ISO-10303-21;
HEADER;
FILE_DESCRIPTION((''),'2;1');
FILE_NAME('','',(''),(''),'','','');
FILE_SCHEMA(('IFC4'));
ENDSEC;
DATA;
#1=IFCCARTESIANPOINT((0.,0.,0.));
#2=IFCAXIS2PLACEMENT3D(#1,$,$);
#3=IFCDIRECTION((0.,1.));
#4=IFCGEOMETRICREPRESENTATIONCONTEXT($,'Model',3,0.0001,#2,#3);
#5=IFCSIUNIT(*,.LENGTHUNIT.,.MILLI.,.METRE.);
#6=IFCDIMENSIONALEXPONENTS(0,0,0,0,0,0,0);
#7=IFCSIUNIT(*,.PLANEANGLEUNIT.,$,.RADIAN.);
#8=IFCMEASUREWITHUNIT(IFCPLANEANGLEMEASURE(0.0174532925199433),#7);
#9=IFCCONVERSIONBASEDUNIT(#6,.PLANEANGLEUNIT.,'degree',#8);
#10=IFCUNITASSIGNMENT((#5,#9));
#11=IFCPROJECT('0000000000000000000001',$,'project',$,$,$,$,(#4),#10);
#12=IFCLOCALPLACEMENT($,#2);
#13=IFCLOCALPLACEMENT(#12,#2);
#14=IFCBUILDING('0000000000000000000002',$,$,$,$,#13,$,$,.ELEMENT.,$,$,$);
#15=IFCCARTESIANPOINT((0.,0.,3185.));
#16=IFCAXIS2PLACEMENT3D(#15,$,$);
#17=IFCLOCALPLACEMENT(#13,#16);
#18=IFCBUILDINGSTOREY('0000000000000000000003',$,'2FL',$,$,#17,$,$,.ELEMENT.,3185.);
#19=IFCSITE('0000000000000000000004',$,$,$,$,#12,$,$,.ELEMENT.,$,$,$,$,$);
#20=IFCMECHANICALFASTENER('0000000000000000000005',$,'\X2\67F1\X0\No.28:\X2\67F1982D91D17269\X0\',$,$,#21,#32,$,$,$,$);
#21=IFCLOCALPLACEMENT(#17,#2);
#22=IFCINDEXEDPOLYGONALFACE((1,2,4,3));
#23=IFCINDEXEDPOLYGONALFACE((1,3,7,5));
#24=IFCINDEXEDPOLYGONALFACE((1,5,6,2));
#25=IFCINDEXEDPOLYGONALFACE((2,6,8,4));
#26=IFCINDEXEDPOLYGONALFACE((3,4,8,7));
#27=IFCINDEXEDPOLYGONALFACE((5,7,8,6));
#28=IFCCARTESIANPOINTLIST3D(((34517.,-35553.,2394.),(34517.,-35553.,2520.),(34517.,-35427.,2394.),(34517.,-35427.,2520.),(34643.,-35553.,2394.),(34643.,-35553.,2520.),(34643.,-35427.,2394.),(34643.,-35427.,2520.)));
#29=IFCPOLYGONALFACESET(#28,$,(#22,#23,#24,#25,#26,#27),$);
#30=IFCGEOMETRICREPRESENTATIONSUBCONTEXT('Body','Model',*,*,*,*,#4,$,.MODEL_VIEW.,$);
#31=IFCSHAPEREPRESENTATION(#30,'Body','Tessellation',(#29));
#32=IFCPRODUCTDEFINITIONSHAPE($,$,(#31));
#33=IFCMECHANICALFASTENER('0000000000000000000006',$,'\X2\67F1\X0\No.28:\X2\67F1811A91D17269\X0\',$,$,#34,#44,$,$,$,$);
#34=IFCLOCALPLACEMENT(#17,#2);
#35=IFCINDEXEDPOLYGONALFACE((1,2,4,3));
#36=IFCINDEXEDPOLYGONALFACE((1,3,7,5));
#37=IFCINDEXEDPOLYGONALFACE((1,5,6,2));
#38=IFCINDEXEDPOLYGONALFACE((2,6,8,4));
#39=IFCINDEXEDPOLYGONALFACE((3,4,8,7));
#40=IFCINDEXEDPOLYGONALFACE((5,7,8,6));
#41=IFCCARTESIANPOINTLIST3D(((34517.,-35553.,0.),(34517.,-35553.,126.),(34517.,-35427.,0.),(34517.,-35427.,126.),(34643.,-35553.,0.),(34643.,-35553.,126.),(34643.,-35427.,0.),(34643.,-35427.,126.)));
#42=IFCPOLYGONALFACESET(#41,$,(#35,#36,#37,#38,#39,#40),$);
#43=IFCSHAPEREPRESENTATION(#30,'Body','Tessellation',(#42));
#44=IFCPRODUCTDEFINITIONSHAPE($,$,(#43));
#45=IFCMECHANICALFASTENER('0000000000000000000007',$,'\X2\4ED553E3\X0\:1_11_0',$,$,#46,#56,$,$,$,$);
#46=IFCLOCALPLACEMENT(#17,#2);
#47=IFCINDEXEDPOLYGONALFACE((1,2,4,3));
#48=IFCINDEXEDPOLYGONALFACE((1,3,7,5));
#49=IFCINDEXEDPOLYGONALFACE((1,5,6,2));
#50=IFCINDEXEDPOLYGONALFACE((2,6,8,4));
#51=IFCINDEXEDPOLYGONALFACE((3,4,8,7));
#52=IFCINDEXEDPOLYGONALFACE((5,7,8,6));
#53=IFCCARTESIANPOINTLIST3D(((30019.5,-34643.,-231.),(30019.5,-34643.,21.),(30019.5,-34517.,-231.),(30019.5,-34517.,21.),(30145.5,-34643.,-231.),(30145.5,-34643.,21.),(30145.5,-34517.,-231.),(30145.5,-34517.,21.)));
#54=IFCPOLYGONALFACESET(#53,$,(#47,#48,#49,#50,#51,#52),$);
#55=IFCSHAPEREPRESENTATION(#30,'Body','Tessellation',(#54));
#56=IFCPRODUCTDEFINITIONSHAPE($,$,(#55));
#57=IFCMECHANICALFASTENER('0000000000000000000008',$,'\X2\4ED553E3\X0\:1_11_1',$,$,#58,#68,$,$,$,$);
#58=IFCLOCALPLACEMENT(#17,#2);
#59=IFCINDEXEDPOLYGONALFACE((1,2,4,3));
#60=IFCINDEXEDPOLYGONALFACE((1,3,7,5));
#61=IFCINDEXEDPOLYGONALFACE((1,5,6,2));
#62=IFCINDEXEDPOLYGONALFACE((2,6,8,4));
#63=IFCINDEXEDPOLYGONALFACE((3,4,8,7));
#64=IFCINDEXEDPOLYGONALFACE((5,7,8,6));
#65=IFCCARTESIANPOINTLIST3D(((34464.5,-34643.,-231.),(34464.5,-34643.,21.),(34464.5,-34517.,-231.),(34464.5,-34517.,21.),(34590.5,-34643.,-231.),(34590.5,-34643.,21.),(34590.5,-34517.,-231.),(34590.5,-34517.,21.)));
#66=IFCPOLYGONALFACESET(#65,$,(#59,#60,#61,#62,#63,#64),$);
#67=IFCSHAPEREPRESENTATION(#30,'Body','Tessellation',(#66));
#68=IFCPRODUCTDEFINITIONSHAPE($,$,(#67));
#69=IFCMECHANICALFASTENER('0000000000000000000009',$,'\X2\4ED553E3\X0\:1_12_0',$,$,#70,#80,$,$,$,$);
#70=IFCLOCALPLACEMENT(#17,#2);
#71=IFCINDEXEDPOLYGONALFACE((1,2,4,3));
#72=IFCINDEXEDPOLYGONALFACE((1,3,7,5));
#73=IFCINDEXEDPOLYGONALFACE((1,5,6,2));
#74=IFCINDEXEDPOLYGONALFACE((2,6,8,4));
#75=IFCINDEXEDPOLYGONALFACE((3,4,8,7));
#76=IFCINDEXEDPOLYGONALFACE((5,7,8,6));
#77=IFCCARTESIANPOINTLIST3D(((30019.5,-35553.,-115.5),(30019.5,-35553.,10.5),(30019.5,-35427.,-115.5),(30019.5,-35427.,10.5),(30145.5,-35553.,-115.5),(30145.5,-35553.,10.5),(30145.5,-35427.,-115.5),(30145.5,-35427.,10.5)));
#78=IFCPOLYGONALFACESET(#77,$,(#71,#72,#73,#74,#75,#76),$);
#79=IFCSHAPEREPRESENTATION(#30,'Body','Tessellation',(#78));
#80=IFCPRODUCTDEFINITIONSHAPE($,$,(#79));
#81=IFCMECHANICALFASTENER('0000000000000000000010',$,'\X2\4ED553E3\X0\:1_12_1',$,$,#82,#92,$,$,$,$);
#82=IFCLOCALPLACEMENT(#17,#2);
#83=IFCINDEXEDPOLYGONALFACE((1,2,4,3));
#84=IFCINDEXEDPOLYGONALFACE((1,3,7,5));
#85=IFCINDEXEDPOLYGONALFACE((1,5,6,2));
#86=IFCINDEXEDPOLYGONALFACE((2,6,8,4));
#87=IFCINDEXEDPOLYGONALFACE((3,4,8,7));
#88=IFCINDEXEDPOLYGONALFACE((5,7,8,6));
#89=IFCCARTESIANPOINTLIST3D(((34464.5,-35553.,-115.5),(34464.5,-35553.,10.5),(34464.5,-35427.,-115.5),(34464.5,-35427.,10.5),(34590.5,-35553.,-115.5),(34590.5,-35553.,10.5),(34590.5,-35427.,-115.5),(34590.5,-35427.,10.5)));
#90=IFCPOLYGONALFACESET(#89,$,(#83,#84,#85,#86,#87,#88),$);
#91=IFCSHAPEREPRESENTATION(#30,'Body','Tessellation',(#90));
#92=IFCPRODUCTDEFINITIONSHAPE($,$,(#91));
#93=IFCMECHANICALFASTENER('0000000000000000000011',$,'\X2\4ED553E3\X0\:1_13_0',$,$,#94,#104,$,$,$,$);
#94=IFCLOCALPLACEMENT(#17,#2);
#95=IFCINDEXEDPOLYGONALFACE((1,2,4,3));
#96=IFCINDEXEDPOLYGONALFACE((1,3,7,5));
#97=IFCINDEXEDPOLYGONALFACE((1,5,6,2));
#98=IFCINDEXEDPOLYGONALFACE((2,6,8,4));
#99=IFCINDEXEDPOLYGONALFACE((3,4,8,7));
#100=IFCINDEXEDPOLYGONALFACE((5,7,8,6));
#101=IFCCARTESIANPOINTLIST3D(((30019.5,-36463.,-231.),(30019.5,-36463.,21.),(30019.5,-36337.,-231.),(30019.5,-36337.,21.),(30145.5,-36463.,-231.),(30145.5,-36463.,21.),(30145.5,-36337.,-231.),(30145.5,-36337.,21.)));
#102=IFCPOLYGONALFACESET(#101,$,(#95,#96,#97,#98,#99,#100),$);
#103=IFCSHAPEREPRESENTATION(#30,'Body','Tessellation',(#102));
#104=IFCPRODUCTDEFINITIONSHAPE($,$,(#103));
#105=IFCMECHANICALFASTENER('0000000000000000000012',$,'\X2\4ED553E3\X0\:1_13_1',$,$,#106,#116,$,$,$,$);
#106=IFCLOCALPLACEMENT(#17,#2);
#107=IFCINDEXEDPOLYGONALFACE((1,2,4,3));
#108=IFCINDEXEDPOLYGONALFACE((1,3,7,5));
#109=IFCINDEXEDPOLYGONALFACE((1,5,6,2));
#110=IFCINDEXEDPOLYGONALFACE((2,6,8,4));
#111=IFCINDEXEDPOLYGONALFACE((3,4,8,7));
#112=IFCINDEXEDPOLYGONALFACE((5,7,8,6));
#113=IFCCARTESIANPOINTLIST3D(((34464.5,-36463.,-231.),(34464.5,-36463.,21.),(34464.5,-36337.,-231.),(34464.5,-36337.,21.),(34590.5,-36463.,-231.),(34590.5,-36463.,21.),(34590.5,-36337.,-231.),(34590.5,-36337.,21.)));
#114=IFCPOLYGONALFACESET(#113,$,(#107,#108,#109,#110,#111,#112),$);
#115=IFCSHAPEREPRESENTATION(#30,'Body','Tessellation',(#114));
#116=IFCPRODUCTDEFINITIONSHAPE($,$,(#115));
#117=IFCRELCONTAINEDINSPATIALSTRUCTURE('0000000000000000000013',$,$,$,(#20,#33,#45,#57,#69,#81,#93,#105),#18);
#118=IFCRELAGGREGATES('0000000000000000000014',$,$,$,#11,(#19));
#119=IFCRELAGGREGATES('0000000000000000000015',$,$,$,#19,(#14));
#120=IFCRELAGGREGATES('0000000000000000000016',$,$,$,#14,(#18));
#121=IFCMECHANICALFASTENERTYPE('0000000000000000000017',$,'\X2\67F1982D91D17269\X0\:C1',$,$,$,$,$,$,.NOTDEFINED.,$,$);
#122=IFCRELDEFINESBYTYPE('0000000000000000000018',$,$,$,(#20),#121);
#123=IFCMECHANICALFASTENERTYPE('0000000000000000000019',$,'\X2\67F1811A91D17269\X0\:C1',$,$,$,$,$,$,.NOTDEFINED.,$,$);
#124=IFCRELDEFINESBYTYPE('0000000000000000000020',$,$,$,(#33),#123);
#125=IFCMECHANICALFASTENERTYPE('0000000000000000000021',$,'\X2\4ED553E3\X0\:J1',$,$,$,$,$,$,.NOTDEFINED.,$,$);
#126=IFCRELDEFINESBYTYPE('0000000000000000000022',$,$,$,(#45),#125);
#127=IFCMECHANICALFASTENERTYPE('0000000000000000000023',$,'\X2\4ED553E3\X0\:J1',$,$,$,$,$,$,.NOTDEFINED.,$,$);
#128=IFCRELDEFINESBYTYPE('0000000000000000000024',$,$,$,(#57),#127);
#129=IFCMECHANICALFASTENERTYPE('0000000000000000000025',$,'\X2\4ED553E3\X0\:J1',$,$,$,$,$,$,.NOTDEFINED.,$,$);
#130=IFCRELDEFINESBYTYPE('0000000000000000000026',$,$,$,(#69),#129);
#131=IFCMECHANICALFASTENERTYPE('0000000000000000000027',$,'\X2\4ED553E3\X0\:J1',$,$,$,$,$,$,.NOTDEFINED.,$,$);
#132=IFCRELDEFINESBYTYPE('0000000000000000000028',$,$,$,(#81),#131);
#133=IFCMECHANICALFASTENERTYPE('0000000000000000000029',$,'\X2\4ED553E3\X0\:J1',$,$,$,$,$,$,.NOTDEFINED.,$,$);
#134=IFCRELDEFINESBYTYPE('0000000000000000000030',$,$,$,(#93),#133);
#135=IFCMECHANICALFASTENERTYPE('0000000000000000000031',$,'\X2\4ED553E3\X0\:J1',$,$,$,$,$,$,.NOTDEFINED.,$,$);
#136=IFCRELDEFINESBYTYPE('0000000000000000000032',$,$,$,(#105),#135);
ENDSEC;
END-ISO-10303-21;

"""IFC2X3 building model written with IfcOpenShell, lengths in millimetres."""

from ifc_helpers import new_model, entity, si_unit, converted_unit, direction, frame, origin, origin_with_axes, origin_2d, place, context, subcontext, project, spatial, rectangle, extrude, type_object, element, save


model = new_model("IFC2X3")

# Units and contexts
model_context = context("Model", 3, precision=0.0001, world=origin(), true_north=direction((0.0, 1.0)))
body_context = subcontext(model_context, "Body", "Model", "MODEL_VIEW")
ifc_project = project(units=[si_unit("LENGTHUNIT", "METRE", prefix="MILLI"), converted_unit("PLANEANGLEUNIT", "degree", entity("IfcPlaneAngleMeasure", 0.0174532925199433), si_unit("PLANEANGLEUNIT", "RADIAN"), dimensions=[0, 0, 0, 0, 0, 0, 0])], contexts=[model_context])

# Site, building, storey
site_placement = place(None, origin())
site = spatial("IfcSite", under=ifc_project, at=site_placement, CompositionType="ELEMENT")
building_placement = place(site_placement, origin())
building = spatial("IfcBuilding", under=site, at=building_placement, CompositionType="ELEMENT")
storey_placement = place(building_placement, frame((0.0, 0.0, 3185.0)))
storey = spatial("IfcBuildingStorey", under=building, at=storey_placement, Name="2FL", CompositionType="ELEMENT", Elevation=3185.0)

# Mechanical fasteners
mechanical_fastener_type_1 = type_object("IfcMechanicalFastenerType", Name="柱頭金物:C1")
mechanical_fastener_1_placement = place(storey_placement, frame((34580.0, -35490.0, 2394.0)))
element("IfcMechanicalFastener", 1, at=mechanical_fastener_1_placement, inside=storey, type_object=mechanical_fastener_type_1, Name="柱No.28:柱頭金物", context=body_context, shape_type="SweptSolid", body=[
    extrude(rectangle(XDim=126.0, YDim=126.0, at=origin_2d()), origin_with_axes(), (0.0, 0.0, 1.0), 126.0),
])
mechanical_fastener_type_2 = type_object("IfcMechanicalFastenerType", Name="柱脚金物:C1")
mechanical_fastener_2_placement = place(storey_placement, frame((34580.0, -35490.0, 0.0)))
element("IfcMechanicalFastener", 2, at=mechanical_fastener_2_placement, inside=storey, type_object=mechanical_fastener_type_2, Name="柱No.28:柱脚金物", context=body_context, shape_type="SweptSolid", body=[
    extrude(rectangle(XDim=126.0, YDim=126.0, at=origin_2d()), origin_with_axes(), (0.0, 0.0, 1.0), 126.0),
])
mechanical_fastener_type_3 = type_object("IfcMechanicalFastenerType", Name="仕口:J1")
mechanical_fastener_3_placement = place(storey_placement, frame((30082.5, -34580.0, -231.0)))
element("IfcMechanicalFastener", 3, at=mechanical_fastener_3_placement, inside=storey, type_object=mechanical_fastener_type_3, Name="仕口:1_11_0", context=body_context, shape_type="SweptSolid", body=[
    extrude(rectangle(XDim=126.0, YDim=126.0, at=origin_2d()), origin_with_axes(), (0.0, 0.0, 1.0), 252.0),
])
mechanical_fastener_type_4 = type_object("IfcMechanicalFastenerType", Name="仕口:J1")
mechanical_fastener_4_placement = place(storey_placement, frame((34527.5, -34580.0, -231.0)))
element("IfcMechanicalFastener", 4, at=mechanical_fastener_4_placement, inside=storey, type_object=mechanical_fastener_type_4, Name="仕口:1_11_1", context=body_context, shape_type="SweptSolid", body=[
    extrude(rectangle(XDim=126.0, YDim=126.0, at=origin_2d()), origin_with_axes(), (0.0, 0.0, 1.0), 252.0),
])
mechanical_fastener_type_5 = type_object("IfcMechanicalFastenerType", Name="仕口:J1")
mechanical_fastener_5_placement = place(storey_placement, frame((30082.5, -35490.0, -115.5)))
element("IfcMechanicalFastener", 5, at=mechanical_fastener_5_placement, inside=storey, type_object=mechanical_fastener_type_5, Name="仕口:1_12_0", context=body_context, shape_type="SweptSolid", body=[
    extrude(rectangle(XDim=126.0, YDim=126.0, at=origin_2d()), origin_with_axes(), (0.0, 0.0, 1.0), 126.0),
])
mechanical_fastener_type_6 = type_object("IfcMechanicalFastenerType", Name="仕口:J1")
mechanical_fastener_6_placement = place(storey_placement, frame((34527.5, -35490.0, -115.5)))
element("IfcMechanicalFastener", 6, at=mechanical_fastener_6_placement, inside=storey, type_object=mechanical_fastener_type_6, Name="仕口:1_12_1", context=body_context, shape_type="SweptSolid", body=[
    extrude(rectangle(XDim=126.0, YDim=126.0, at=origin_2d()), origin_with_axes(), (0.0, 0.0, 1.0), 126.0),
])
mechanical_fastener_type_7 = type_object("IfcMechanicalFastenerType", Name="仕口:J1")
mechanical_fastener_7_placement = place(storey_placement, frame((30082.5, -36400.0, -231.0)))
element("IfcMechanicalFastener", 7, at=mechanical_fastener_7_placement, inside=storey, type_object=mechanical_fastener_type_7, Name="仕口:1_13_0", context=body_context, shape_type="SweptSolid", body=[
    extrude(rectangle(XDim=126.0, YDim=126.0, at=origin_2d()), origin_with_axes(), (0.0, 0.0, 1.0), 252.0),
])
mechanical_fastener_type_8 = type_object("IfcMechanicalFastenerType", Name="仕口:J1")
mechanical_fastener_8_placement = place(storey_placement, frame((34527.5, -36400.0, -231.0)))
element("IfcMechanicalFastener", 8, at=mechanical_fastener_8_placement, inside=storey, type_object=mechanical_fastener_type_8, Name="仕口:1_13_1", context=body_context, shape_type="SweptSolid", body=[
    extrude(rectangle(XDim=126.0, YDim=126.0, at=origin_2d()), origin_with_axes(), (0.0, 0.0, 1.0), 252.0),
])

save(model, "model.ifc")
